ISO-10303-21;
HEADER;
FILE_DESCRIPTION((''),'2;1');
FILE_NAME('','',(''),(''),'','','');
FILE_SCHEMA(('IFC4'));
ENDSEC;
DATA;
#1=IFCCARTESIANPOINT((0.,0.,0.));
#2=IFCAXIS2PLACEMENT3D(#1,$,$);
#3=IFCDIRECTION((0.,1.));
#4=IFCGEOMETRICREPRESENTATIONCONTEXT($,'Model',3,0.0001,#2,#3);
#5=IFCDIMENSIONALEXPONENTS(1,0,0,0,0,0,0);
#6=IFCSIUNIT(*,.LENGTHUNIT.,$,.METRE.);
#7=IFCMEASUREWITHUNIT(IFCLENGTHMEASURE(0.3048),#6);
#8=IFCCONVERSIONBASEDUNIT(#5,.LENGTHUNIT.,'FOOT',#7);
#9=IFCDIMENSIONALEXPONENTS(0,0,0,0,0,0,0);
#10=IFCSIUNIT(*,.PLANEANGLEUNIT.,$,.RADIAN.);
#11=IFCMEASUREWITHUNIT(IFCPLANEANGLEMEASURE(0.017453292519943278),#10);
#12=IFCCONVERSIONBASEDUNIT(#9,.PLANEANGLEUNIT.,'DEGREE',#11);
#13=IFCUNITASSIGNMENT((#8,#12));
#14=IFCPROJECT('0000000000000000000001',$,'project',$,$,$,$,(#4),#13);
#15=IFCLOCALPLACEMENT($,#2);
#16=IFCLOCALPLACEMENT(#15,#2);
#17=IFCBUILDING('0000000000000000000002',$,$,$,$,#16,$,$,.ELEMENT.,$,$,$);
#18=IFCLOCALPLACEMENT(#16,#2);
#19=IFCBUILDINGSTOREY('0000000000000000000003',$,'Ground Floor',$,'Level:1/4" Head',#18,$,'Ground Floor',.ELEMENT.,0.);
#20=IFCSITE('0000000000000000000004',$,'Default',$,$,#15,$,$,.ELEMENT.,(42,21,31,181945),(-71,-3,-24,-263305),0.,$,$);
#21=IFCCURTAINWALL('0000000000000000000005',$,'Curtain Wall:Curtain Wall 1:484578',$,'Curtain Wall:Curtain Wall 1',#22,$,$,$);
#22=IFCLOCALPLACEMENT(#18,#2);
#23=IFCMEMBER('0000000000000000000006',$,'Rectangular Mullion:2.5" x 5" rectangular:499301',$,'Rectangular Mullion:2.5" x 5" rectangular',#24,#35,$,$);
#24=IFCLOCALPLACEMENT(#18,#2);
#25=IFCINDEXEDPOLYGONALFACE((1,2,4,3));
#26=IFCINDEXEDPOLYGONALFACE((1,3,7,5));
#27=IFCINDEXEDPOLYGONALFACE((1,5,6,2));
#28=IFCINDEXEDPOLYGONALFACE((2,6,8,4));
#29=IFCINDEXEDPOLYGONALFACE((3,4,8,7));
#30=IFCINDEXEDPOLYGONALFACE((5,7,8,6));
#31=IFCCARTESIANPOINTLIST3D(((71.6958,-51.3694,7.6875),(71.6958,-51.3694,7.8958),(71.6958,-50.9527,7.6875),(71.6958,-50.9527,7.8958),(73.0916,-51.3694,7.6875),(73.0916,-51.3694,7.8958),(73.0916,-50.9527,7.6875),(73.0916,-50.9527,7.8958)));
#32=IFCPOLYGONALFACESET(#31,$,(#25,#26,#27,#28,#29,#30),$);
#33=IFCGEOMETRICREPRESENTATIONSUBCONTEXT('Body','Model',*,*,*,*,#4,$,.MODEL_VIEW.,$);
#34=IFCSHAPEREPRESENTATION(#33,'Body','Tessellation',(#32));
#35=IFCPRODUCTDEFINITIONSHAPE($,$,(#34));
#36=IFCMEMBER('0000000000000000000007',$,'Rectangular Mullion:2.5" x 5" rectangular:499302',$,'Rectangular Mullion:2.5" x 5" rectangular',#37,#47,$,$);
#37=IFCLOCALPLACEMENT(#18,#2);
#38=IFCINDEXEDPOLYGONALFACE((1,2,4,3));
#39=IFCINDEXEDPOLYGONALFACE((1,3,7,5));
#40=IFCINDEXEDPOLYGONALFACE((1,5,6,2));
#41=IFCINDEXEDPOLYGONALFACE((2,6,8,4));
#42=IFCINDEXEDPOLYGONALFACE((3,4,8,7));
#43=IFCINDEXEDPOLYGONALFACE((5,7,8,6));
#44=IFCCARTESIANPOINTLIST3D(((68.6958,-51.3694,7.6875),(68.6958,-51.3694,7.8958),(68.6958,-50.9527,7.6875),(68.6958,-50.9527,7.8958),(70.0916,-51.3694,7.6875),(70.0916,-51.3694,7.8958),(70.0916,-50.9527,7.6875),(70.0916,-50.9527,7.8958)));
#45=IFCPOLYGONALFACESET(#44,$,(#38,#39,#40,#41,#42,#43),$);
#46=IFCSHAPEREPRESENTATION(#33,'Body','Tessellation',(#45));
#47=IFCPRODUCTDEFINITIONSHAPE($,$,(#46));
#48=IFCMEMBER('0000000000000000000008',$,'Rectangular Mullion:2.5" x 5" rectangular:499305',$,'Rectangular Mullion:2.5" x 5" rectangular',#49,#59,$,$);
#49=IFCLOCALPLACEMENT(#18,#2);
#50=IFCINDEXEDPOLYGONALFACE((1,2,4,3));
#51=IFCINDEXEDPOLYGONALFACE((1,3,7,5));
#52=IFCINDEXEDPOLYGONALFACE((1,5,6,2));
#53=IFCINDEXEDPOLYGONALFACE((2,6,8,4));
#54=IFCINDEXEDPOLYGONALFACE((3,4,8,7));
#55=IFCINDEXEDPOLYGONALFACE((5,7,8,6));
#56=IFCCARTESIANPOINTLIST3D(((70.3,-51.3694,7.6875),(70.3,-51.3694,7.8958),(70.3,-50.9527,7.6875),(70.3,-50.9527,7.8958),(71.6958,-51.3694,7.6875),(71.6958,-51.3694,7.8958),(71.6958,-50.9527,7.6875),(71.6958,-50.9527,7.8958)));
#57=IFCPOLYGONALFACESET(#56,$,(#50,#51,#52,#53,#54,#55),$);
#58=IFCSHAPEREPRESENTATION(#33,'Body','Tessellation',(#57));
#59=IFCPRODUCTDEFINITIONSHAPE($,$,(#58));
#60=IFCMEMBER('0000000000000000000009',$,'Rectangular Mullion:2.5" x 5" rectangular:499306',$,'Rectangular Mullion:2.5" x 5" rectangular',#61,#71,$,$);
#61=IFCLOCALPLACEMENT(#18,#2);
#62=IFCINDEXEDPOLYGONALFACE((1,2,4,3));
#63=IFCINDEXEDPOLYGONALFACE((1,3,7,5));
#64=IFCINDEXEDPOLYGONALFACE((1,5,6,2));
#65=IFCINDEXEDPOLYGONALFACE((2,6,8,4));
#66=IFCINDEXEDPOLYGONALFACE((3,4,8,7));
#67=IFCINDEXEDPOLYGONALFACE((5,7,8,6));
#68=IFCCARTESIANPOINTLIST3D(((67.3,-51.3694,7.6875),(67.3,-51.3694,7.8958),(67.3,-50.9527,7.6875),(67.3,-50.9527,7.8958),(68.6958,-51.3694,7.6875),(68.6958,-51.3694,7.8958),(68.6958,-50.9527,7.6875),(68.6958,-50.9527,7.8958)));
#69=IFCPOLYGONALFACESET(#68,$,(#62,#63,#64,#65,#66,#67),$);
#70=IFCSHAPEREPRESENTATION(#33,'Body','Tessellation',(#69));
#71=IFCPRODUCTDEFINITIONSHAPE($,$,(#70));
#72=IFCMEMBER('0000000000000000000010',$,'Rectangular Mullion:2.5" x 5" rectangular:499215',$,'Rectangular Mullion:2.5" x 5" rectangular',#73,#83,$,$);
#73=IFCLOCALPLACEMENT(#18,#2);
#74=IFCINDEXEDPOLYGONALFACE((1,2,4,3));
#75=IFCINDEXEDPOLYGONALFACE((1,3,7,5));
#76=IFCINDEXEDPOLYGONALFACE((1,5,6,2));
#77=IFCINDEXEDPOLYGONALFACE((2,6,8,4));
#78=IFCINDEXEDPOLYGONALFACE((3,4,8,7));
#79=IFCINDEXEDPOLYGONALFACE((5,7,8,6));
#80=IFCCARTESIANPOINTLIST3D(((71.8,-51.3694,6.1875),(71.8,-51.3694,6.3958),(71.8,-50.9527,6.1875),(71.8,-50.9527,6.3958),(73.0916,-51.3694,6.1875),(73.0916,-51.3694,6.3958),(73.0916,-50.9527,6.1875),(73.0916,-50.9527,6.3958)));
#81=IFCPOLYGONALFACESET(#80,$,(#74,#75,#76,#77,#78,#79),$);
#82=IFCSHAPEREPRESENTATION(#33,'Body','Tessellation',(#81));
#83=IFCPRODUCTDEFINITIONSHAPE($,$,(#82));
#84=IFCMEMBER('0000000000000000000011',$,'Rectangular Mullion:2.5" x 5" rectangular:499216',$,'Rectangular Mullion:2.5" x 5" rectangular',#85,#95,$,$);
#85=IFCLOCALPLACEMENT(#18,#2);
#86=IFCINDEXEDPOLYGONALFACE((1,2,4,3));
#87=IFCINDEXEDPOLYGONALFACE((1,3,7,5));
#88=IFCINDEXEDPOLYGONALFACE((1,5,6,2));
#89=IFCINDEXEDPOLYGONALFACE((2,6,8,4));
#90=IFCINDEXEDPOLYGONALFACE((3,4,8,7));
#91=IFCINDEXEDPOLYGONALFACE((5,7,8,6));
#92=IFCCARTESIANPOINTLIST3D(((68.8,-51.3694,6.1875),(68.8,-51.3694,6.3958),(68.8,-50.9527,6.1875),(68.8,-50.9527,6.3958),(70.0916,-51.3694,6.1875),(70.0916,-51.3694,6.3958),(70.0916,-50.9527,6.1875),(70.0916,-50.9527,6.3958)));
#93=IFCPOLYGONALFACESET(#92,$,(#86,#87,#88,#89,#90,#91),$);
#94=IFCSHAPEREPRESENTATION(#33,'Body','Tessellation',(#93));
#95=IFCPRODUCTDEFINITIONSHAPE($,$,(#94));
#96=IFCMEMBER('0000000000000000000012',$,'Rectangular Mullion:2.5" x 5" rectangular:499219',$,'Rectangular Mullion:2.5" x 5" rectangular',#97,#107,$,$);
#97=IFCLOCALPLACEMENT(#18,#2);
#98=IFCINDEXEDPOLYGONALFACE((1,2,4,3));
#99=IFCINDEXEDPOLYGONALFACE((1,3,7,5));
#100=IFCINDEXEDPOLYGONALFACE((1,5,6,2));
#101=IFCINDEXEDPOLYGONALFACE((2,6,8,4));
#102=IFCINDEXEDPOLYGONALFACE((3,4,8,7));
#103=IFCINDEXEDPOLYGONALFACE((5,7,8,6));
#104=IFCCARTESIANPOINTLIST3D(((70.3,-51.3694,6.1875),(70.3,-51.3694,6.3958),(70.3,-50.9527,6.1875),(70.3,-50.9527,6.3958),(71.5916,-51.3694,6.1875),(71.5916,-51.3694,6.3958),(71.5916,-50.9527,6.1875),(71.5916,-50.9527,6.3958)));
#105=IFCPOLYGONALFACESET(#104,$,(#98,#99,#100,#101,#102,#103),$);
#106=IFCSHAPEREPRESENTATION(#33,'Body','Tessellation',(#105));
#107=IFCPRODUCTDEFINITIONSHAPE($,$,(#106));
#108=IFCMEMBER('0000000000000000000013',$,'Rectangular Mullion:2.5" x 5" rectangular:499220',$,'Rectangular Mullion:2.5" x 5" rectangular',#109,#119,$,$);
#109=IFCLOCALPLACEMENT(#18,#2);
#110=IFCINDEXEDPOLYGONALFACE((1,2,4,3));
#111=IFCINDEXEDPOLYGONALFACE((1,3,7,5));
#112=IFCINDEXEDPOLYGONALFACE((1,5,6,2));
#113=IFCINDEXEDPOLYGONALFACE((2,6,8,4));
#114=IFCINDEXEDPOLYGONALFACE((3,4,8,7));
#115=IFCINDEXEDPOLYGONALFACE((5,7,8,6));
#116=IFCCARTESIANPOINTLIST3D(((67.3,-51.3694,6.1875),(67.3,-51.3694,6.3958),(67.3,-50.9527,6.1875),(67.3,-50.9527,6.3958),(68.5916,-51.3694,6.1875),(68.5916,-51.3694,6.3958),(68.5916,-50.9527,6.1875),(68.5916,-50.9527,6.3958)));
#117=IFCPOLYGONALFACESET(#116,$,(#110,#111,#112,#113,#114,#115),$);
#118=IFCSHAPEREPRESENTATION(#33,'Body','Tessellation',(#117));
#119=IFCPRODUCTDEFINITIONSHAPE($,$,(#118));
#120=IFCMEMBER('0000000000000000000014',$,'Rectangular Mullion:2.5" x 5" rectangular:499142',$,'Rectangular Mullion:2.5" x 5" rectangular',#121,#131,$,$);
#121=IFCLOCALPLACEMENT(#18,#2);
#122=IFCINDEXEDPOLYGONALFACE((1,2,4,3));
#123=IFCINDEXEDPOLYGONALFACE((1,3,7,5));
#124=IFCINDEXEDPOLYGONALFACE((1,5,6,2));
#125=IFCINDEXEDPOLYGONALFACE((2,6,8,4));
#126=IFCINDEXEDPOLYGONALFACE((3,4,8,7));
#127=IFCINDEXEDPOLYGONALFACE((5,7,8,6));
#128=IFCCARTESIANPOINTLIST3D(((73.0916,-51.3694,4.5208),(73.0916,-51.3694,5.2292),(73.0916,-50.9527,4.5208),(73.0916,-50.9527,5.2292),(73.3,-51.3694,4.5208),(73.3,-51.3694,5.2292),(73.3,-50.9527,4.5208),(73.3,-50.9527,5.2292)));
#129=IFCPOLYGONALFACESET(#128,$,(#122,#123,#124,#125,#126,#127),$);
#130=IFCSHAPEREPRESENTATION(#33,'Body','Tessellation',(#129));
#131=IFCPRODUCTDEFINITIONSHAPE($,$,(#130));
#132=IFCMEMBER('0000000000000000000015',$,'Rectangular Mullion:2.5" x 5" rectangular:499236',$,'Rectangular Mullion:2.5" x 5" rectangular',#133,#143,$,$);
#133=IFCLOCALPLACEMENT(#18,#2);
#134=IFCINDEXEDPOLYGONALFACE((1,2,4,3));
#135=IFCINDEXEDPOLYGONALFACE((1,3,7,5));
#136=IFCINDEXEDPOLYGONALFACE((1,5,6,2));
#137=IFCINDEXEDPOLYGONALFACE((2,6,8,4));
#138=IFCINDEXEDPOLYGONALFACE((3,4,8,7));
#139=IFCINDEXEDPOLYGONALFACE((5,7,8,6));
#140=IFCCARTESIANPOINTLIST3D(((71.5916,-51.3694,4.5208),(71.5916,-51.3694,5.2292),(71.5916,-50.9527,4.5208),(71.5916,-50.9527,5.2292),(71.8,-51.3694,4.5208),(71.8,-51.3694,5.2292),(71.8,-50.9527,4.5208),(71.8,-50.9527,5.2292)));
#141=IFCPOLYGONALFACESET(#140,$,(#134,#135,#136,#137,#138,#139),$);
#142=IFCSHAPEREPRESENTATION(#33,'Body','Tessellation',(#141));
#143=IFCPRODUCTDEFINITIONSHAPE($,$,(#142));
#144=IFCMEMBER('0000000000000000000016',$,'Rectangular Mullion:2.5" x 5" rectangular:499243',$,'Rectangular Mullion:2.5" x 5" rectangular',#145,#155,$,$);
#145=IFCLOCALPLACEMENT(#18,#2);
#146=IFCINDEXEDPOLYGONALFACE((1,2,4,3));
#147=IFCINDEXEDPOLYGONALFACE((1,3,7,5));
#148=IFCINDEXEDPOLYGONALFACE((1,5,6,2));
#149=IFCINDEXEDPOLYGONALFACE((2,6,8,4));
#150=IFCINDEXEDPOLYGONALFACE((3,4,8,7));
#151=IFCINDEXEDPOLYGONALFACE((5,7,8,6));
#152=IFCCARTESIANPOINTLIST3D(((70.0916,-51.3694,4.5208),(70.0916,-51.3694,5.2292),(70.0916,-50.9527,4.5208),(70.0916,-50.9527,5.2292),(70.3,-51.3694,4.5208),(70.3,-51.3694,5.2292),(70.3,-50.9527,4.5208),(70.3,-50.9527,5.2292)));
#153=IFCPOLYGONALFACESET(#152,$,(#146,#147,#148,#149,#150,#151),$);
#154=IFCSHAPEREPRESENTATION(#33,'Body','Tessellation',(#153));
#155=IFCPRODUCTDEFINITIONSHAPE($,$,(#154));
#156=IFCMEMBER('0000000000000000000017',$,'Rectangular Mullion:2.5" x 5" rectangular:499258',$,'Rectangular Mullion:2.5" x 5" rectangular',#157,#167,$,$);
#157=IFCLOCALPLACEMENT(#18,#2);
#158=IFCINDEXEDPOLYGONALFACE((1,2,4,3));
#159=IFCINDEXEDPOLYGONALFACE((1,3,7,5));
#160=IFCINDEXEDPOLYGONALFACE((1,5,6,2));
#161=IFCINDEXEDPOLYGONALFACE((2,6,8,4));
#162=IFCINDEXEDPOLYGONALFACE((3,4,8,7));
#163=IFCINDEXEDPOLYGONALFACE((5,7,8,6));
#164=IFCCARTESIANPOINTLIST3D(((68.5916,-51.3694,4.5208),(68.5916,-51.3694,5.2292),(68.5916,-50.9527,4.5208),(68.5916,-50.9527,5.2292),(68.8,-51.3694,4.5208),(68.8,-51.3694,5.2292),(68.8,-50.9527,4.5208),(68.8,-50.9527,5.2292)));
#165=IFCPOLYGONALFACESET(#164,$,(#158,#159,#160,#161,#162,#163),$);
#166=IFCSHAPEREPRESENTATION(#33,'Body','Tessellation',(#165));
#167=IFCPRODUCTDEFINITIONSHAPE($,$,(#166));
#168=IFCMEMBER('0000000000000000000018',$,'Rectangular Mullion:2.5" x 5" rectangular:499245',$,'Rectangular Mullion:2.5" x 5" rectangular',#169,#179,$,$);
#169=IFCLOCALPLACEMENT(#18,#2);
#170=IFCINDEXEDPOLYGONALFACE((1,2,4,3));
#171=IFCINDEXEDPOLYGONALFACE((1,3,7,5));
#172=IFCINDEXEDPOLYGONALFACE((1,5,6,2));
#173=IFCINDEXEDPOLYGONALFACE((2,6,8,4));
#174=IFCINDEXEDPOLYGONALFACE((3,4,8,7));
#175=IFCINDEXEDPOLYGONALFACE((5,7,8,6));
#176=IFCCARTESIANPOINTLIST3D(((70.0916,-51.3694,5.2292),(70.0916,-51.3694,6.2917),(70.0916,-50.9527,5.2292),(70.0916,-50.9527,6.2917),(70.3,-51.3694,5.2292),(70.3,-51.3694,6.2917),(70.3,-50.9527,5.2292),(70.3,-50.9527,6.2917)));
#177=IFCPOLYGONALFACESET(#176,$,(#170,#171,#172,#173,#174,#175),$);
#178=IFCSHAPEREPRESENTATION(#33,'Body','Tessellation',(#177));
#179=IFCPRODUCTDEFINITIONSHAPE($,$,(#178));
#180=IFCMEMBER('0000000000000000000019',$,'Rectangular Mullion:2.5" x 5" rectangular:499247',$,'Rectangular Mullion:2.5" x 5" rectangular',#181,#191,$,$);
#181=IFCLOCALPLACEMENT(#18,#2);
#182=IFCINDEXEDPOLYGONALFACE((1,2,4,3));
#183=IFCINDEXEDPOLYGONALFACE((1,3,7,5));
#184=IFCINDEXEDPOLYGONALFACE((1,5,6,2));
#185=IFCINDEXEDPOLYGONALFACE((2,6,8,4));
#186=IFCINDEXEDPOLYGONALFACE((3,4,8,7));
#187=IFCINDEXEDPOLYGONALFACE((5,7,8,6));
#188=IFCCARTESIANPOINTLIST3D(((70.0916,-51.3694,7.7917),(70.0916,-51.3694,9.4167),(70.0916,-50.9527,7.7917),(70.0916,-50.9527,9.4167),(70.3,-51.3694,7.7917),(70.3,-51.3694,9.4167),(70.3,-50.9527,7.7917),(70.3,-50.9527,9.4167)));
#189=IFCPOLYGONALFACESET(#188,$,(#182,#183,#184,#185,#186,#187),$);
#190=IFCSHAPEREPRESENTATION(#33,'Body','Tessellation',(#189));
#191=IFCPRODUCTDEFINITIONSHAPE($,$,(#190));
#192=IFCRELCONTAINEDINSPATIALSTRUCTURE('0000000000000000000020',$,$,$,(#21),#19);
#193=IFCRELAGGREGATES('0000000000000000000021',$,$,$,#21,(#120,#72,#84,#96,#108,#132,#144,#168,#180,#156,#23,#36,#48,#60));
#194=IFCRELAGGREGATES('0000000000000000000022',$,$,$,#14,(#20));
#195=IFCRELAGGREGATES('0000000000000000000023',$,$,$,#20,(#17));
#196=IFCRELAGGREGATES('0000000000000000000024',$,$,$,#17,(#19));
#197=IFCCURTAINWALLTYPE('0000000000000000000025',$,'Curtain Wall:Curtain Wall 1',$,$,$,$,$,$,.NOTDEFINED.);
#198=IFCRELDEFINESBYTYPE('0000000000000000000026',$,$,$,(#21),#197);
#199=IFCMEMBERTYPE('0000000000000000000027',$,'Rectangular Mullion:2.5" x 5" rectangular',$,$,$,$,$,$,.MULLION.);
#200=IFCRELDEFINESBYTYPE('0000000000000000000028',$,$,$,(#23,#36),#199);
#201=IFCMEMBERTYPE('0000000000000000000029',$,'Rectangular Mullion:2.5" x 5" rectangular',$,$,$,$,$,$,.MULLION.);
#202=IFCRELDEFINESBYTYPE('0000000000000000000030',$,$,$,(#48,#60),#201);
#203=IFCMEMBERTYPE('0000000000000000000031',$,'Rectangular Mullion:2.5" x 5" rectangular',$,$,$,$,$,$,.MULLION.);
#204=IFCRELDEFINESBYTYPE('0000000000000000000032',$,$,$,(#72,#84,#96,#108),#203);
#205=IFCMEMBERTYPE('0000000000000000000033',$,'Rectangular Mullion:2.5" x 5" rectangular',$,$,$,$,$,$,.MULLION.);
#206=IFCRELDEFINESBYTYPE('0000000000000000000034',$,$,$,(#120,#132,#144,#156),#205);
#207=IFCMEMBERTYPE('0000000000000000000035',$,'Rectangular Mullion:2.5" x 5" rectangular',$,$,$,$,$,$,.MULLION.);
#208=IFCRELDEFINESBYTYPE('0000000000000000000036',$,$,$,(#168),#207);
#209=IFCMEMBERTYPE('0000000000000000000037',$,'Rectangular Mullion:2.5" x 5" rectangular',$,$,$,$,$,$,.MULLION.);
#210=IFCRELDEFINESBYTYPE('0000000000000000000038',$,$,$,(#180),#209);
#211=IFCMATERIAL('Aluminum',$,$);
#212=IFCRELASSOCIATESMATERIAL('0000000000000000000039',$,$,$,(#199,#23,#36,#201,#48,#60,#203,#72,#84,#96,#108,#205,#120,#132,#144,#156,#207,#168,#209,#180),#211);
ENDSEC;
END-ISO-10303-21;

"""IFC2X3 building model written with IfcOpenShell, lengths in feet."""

from ifc_helpers import new_model, entity, si_unit, converted_unit, direction, frame, origin, origin_2d_with_axis, place, context, subcontext, project, spatial, rectangle, extrude, source, transform, mapped, material, type_object, type_shapes, element, aggregate, save


model = new_model("IFC2X3")

# Units and contexts
model_context = context("Model", 3, precision=0.0001, world=origin(), true_north=direction((0.0, 1.0)))
body_context = subcontext(model_context, "Body", "Model", "MODEL_VIEW")
ifc_project = project(units=[converted_unit("LENGTHUNIT", "FOOT", entity("IfcLengthMeasure", 0.3048), si_unit("LENGTHUNIT", "METRE"), dimensions=[1, 0, 0, 0, 0, 0, 0]), converted_unit("PLANEANGLEUNIT", "DEGREE", entity("IfcPlaneAngleMeasure", 0.017453292519943278), si_unit("PLANEANGLEUNIT", "RADIAN"), dimensions=[0, 0, 0, 0, 0, 0, 0])], contexts=[model_context])

# Site, building, storey
site_placement = place(None, origin())
site = spatial("IfcSite", under=ifc_project, at=site_placement, Name="Default", CompositionType="ELEMENT", RefLatitude=(42, 21, 31, 181945), RefLongitude=(-71, -3, -24, -263305), RefElevation=0.0)
building_placement = place(site_placement, origin())
building = spatial("IfcBuilding", under=site, at=building_placement, CompositionType="ELEMENT")
storey_placement = place(building_placement, origin())
storey = spatial("IfcBuildingStorey", under=building, at=storey_placement, Name="Ground Floor", ObjectType="Level:1/4\" Head", LongName="Ground Floor", CompositionType="ELEMENT", Elevation=0.0)

# Curtain wall, members
curtain_wall_type = type_object("IfcCurtainWallType", Name="Curtain Wall:Curtain Wall 1", PredefinedType="NOTDEFINED")
curtain_wall_placement = place(storey_placement, origin())
curtain_wall = element("IfcCurtainWall", 1, at=curtain_wall_placement, inside=storey, type_object=curtain_wall_type, Name="Curtain Wall:Curtain Wall 1:484578", ObjectType="Curtain Wall:Curtain Wall 1")
ifc_material_1 = material(Name="Aluminum")
member_type_1 = type_object("IfcMemberType", Name="Rectangular Mullion:2.5\" x 5\" rectangular", PredefinedType="MULLION", material=ifc_material_1)
shared_shape_1 = source(origin(), body_context, "Body", "SweptSolid", [
    extrude(rectangle(XDim=0.2083, YDim=0.4167, at=origin_2d_with_axis()), frame((0.0, 0.0, -1.3958), z_axis=(0.0, 0.0, 1.0), x_axis=(-1.0, 0.0, 0.0)), (0.0, 0.0, 1.0), 1.3958),
])
type_shapes(member_type_1, [shared_shape_1])
member_1_placement = place(curtain_wall_placement, frame((73.0916, -51.161, 7.7917), z_axis=(1.0, 0.0, 0.0), x_axis=(0.0, 0.0, 1.0)))
member_1 = element("IfcMember", 2, at=member_1_placement, type_object=member_type_1, material=ifc_material_1, Name="Rectangular Mullion:2.5\" x 5\" rectangular:499301", ObjectType="Rectangular Mullion:2.5\" x 5\" rectangular", context=body_context, shape_type="MappedRepresentation", body=[
    mapped(shared_shape_1, transform((0.0, 0.0, 0.0), scale=1.0)),
])
member_2_placement = place(curtain_wall_placement, frame((70.0916, -51.161, 7.7917), z_axis=(1.0, 0.0, 0.0), x_axis=(0.0, 0.0, 1.0)))
member_2 = element("IfcMember", 3, at=member_2_placement, type_object=member_type_1, material=ifc_material_1, Name="Rectangular Mullion:2.5\" x 5\" rectangular:499302", ObjectType="Rectangular Mullion:2.5\" x 5\" rectangular", context=body_context, shape_type="MappedRepresentation", body=[
    mapped(shared_shape_1, transform((0.0, 0.0, 0.0), scale=1.0)),
])
member_type_2 = type_object("IfcMemberType", Name="Rectangular Mullion:2.5\" x 5\" rectangular", PredefinedType="MULLION", material=ifc_material_1)
shared_shape_2 = source(origin(), body_context, "Body", "SweptSolid", [
    extrude(rectangle(XDim=0.2083, YDim=0.4167, at=origin_2d_with_axis()), frame((0.0, 0.0, -1.3958), z_axis=(0.0, 0.0, 1.0), x_axis=(-1.0, 0.0, 0.0)), (0.0, 0.0, 1.0), 1.3958),
])
type_shapes(member_type_2, [shared_shape_2])
member_3_placement = place(curtain_wall_placement, frame((71.6958, -51.161, 7.7917), z_axis=(1.0, 0.0, 0.0), x_axis=(0.0, 0.0, 1.0)))
member_3 = element("IfcMember", 4, at=member_3_placement, type_object=member_type_2, material=ifc_material_1, Name="Rectangular Mullion:2.5\" x 5\" rectangular:499305", ObjectType="Rectangular Mullion:2.5\" x 5\" rectangular", context=body_context, shape_type="MappedRepresentation", body=[
    mapped(shared_shape_2, transform((0.0, 0.0, 0.0), scale=1.0)),
])
member_4_placement = place(curtain_wall_placement, frame((68.6958, -51.161, 7.7917), z_axis=(1.0, 0.0, 0.0), x_axis=(0.0, 0.0, 1.0)))
member_4 = element("IfcMember", 5, at=member_4_placement, type_object=member_type_2, material=ifc_material_1, Name="Rectangular Mullion:2.5\" x 5\" rectangular:499306", ObjectType="Rectangular Mullion:2.5\" x 5\" rectangular", context=body_context, shape_type="MappedRepresentation", body=[
    mapped(shared_shape_2, transform((0.0, 0.0, 0.0), scale=1.0)),
])
member_type_3 = type_object("IfcMemberType", Name="Rectangular Mullion:2.5\" x 5\" rectangular", PredefinedType="MULLION", material=ifc_material_1)
shared_shape_3 = source(origin(), body_context, "Body", "SweptSolid", [
    extrude(rectangle(XDim=0.2083, YDim=0.4167, at=origin_2d_with_axis()), frame((0.0, 0.0, -1.2917), z_axis=(0.0, 0.0, 1.0), x_axis=(-1.0, 0.0, 0.0)), (0.0, 0.0, 1.0), 1.2917),
])
type_shapes(member_type_3, [shared_shape_3])
member_5_placement = place(curtain_wall_placement, frame((73.0916, -51.161, 6.2917), z_axis=(1.0, 0.0, 0.0), x_axis=(0.0, 0.0, 1.0)))
member_5 = element("IfcMember", 6, at=member_5_placement, type_object=member_type_3, material=ifc_material_1, Name="Rectangular Mullion:2.5\" x 5\" rectangular:499215", ObjectType="Rectangular Mullion:2.5\" x 5\" rectangular", context=body_context, shape_type="MappedRepresentation", body=[
    mapped(shared_shape_3, transform((0.0, 0.0, 0.0), scale=1.0)),
])
member_6_placement = place(curtain_wall_placement, frame((70.0916, -51.161, 6.2917), z_axis=(1.0, 0.0, 0.0), x_axis=(0.0, 0.0, 1.0)))
member_6 = element("IfcMember", 7, at=member_6_placement, type_object=member_type_3, material=ifc_material_1, Name="Rectangular Mullion:2.5\" x 5\" rectangular:499216", ObjectType="Rectangular Mullion:2.5\" x 5\" rectangular", context=body_context, shape_type="MappedRepresentation", body=[
    mapped(shared_shape_3, transform((0.0, 0.0, 0.0), scale=1.0)),
])
member_7_placement = place(curtain_wall_placement, frame((71.5916, -51.161, 6.2917), z_axis=(1.0, 0.0, 0.0), x_axis=(0.0, 0.0, 1.0)))
member_7 = element("IfcMember", 8, at=member_7_placement, type_object=member_type_3, material=ifc_material_1, Name="Rectangular Mullion:2.5\" x 5\" rectangular:499219", ObjectType="Rectangular Mullion:2.5\" x 5\" rectangular", context=body_context, shape_type="MappedRepresentation", body=[
    mapped(shared_shape_3, transform((0.0, 0.0, 0.0), scale=1.0)),
])
member_8_placement = place(curtain_wall_placement, frame((68.5916, -51.161, 6.2917), z_axis=(1.0, 0.0, 0.0), x_axis=(0.0, 0.0, 1.0)))
member_8 = element("IfcMember", 9, at=member_8_placement, type_object=member_type_3, material=ifc_material_1, Name="Rectangular Mullion:2.5\" x 5\" rectangular:499220", ObjectType="Rectangular Mullion:2.5\" x 5\" rectangular", context=body_context, shape_type="MappedRepresentation", body=[
    mapped(shared_shape_3, transform((0.0, 0.0, 0.0), scale=1.0)),
])
member_type_4 = type_object("IfcMemberType", Name="Rectangular Mullion:2.5\" x 5\" rectangular", PredefinedType="MULLION", material=ifc_material_1)
shared_shape_4 = source(origin(), body_context, "Body", "SweptSolid", [
    extrude(rectangle(XDim=0.2083, YDim=0.4167, at=origin_2d_with_axis()), frame((0.0, 0.0, -0.7083), z_axis=(0.0, 0.0, 1.0), x_axis=(-1.0, 0.0, 0.0)), (0.0, 0.0, 1.0), 0.7083),
])
type_shapes(member_type_4, [shared_shape_4])
member_9_placement = place(curtain_wall_placement, frame((73.1958, -51.161, 4.5208), z_axis=(0.0, 0.0, -1.0), x_axis=(1.0, 0.0, 0.0)))
member_9 = element("IfcMember", 10, at=member_9_placement, type_object=member_type_4, material=ifc_material_1, Name="Rectangular Mullion:2.5\" x 5\" rectangular:499142", ObjectType="Rectangular Mullion:2.5\" x 5\" rectangular", context=body_context, shape_type="MappedRepresentation", body=[
    mapped(shared_shape_4, transform((0.0, 0.0, 0.0), scale=1.0)),
])
member_10_placement = place(curtain_wall_placement, frame((71.6958, -51.161, 4.5208), z_axis=(0.0, 0.0, -1.0), x_axis=(1.0, 0.0, 0.0)))
member_10 = element("IfcMember", 11, at=member_10_placement, type_object=member_type_4, material=ifc_material_1, Name="Rectangular Mullion:2.5\" x 5\" rectangular:499236", ObjectType="Rectangular Mullion:2.5\" x 5\" rectangular", context=body_context, shape_type="MappedRepresentation", body=[
    mapped(shared_shape_4, transform((0.0, 0.0, 0.0), scale=1.0)),
])
member_11_placement = place(curtain_wall_placement, frame((70.1958, -51.161, 4.5208), z_axis=(0.0, 0.0, -1.0), x_axis=(1.0, 0.0, 0.0)))
member_11 = element("IfcMember", 12, at=member_11_placement, type_object=member_type_4, material=ifc_material_1, Name="Rectangular Mullion:2.5\" x 5\" rectangular:499243", ObjectType="Rectangular Mullion:2.5\" x 5\" rectangular", context=body_context, shape_type="MappedRepresentation", body=[
    mapped(shared_shape_4, transform((0.0, 0.0, 0.0), scale=1.0)),
])
member_12_placement = place(curtain_wall_placement, frame((68.6958, -51.161, 4.5208), z_axis=(0.0, 0.0, -1.0), x_axis=(1.0, 0.0, 0.0)))
member_12 = element("IfcMember", 13, at=member_12_placement, type_object=member_type_4, material=ifc_material_1, Name="Rectangular Mullion:2.5\" x 5\" rectangular:499258", ObjectType="Rectangular Mullion:2.5\" x 5\" rectangular", context=body_context, shape_type="MappedRepresentation", body=[
    mapped(shared_shape_4, transform((0.0, 0.0, 0.0), scale=1.0)),
])
member_type_5 = type_object("IfcMemberType", Name="Rectangular Mullion:2.5\" x 5\" rectangular", PredefinedType="MULLION", material=ifc_material_1)
shared_shape_5 = source(origin(), body_context, "Body", "SweptSolid", [
    extrude(rectangle(XDim=0.2083, YDim=0.4167, at=origin_2d_with_axis()), frame((0.0, 0.0, -1.0625), z_axis=(0.0, 0.0, 1.0), x_axis=(-1.0, 0.0, 0.0)), (0.0, 0.0, 1.0), 1.0625),
])
type_shapes(member_type_5, [shared_shape_5])
member_13_placement = place(curtain_wall_placement, frame((70.1958, -51.161, 5.2292), z_axis=(0.0, 0.0, -1.0), x_axis=(1.0, 0.0, 0.0)))
member_13 = element("IfcMember", 14, at=member_13_placement, type_object=member_type_5, material=ifc_material_1, Name="Rectangular Mullion:2.5\" x 5\" rectangular:499245", ObjectType="Rectangular Mullion:2.5\" x 5\" rectangular", context=body_context, shape_type="MappedRepresentation", body=[
    mapped(shared_shape_5, transform((0.0, 0.0, 0.0), scale=1.0)),
])
member_type_6 = type_object("IfcMemberType", Name="Rectangular Mullion:2.5\" x 5\" rectangular", PredefinedType="MULLION", material=ifc_material_1)
shared_shape_6 = source(origin(), body_context, "Body", "SweptSolid", [
    extrude(rectangle(XDim=0.2083, YDim=0.4167, at=origin_2d_with_axis()), frame((0.0, 0.0, -1.625), z_axis=(0.0, 0.0, 1.0), x_axis=(-1.0, 0.0, 0.0)), (0.0, 0.0, 1.0), 1.625),
])
type_shapes(member_type_6, [shared_shape_6])
member_14_placement = place(curtain_wall_placement, frame((70.1958, -51.161, 7.7917), z_axis=(0.0, 0.0, -1.0), x_axis=(1.0, 0.0, 0.0)))
member_14 = element("IfcMember", 15, at=member_14_placement, type_object=member_type_6, material=ifc_material_1, Name="Rectangular Mullion:2.5\" x 5\" rectangular:499247", ObjectType="Rectangular Mullion:2.5\" x 5\" rectangular", context=body_context, shape_type="MappedRepresentation", body=[
    mapped(shared_shape_6, transform((0.0, 0.0, 0.0), scale=1.0)),
])
aggregate(curtain_wall, [member_9, member_5, member_6, member_7, member_8, member_10, member_11, member_13, member_14, member_12, member_1, member_2, member_3, member_4])

save(model, "model.ifc")
